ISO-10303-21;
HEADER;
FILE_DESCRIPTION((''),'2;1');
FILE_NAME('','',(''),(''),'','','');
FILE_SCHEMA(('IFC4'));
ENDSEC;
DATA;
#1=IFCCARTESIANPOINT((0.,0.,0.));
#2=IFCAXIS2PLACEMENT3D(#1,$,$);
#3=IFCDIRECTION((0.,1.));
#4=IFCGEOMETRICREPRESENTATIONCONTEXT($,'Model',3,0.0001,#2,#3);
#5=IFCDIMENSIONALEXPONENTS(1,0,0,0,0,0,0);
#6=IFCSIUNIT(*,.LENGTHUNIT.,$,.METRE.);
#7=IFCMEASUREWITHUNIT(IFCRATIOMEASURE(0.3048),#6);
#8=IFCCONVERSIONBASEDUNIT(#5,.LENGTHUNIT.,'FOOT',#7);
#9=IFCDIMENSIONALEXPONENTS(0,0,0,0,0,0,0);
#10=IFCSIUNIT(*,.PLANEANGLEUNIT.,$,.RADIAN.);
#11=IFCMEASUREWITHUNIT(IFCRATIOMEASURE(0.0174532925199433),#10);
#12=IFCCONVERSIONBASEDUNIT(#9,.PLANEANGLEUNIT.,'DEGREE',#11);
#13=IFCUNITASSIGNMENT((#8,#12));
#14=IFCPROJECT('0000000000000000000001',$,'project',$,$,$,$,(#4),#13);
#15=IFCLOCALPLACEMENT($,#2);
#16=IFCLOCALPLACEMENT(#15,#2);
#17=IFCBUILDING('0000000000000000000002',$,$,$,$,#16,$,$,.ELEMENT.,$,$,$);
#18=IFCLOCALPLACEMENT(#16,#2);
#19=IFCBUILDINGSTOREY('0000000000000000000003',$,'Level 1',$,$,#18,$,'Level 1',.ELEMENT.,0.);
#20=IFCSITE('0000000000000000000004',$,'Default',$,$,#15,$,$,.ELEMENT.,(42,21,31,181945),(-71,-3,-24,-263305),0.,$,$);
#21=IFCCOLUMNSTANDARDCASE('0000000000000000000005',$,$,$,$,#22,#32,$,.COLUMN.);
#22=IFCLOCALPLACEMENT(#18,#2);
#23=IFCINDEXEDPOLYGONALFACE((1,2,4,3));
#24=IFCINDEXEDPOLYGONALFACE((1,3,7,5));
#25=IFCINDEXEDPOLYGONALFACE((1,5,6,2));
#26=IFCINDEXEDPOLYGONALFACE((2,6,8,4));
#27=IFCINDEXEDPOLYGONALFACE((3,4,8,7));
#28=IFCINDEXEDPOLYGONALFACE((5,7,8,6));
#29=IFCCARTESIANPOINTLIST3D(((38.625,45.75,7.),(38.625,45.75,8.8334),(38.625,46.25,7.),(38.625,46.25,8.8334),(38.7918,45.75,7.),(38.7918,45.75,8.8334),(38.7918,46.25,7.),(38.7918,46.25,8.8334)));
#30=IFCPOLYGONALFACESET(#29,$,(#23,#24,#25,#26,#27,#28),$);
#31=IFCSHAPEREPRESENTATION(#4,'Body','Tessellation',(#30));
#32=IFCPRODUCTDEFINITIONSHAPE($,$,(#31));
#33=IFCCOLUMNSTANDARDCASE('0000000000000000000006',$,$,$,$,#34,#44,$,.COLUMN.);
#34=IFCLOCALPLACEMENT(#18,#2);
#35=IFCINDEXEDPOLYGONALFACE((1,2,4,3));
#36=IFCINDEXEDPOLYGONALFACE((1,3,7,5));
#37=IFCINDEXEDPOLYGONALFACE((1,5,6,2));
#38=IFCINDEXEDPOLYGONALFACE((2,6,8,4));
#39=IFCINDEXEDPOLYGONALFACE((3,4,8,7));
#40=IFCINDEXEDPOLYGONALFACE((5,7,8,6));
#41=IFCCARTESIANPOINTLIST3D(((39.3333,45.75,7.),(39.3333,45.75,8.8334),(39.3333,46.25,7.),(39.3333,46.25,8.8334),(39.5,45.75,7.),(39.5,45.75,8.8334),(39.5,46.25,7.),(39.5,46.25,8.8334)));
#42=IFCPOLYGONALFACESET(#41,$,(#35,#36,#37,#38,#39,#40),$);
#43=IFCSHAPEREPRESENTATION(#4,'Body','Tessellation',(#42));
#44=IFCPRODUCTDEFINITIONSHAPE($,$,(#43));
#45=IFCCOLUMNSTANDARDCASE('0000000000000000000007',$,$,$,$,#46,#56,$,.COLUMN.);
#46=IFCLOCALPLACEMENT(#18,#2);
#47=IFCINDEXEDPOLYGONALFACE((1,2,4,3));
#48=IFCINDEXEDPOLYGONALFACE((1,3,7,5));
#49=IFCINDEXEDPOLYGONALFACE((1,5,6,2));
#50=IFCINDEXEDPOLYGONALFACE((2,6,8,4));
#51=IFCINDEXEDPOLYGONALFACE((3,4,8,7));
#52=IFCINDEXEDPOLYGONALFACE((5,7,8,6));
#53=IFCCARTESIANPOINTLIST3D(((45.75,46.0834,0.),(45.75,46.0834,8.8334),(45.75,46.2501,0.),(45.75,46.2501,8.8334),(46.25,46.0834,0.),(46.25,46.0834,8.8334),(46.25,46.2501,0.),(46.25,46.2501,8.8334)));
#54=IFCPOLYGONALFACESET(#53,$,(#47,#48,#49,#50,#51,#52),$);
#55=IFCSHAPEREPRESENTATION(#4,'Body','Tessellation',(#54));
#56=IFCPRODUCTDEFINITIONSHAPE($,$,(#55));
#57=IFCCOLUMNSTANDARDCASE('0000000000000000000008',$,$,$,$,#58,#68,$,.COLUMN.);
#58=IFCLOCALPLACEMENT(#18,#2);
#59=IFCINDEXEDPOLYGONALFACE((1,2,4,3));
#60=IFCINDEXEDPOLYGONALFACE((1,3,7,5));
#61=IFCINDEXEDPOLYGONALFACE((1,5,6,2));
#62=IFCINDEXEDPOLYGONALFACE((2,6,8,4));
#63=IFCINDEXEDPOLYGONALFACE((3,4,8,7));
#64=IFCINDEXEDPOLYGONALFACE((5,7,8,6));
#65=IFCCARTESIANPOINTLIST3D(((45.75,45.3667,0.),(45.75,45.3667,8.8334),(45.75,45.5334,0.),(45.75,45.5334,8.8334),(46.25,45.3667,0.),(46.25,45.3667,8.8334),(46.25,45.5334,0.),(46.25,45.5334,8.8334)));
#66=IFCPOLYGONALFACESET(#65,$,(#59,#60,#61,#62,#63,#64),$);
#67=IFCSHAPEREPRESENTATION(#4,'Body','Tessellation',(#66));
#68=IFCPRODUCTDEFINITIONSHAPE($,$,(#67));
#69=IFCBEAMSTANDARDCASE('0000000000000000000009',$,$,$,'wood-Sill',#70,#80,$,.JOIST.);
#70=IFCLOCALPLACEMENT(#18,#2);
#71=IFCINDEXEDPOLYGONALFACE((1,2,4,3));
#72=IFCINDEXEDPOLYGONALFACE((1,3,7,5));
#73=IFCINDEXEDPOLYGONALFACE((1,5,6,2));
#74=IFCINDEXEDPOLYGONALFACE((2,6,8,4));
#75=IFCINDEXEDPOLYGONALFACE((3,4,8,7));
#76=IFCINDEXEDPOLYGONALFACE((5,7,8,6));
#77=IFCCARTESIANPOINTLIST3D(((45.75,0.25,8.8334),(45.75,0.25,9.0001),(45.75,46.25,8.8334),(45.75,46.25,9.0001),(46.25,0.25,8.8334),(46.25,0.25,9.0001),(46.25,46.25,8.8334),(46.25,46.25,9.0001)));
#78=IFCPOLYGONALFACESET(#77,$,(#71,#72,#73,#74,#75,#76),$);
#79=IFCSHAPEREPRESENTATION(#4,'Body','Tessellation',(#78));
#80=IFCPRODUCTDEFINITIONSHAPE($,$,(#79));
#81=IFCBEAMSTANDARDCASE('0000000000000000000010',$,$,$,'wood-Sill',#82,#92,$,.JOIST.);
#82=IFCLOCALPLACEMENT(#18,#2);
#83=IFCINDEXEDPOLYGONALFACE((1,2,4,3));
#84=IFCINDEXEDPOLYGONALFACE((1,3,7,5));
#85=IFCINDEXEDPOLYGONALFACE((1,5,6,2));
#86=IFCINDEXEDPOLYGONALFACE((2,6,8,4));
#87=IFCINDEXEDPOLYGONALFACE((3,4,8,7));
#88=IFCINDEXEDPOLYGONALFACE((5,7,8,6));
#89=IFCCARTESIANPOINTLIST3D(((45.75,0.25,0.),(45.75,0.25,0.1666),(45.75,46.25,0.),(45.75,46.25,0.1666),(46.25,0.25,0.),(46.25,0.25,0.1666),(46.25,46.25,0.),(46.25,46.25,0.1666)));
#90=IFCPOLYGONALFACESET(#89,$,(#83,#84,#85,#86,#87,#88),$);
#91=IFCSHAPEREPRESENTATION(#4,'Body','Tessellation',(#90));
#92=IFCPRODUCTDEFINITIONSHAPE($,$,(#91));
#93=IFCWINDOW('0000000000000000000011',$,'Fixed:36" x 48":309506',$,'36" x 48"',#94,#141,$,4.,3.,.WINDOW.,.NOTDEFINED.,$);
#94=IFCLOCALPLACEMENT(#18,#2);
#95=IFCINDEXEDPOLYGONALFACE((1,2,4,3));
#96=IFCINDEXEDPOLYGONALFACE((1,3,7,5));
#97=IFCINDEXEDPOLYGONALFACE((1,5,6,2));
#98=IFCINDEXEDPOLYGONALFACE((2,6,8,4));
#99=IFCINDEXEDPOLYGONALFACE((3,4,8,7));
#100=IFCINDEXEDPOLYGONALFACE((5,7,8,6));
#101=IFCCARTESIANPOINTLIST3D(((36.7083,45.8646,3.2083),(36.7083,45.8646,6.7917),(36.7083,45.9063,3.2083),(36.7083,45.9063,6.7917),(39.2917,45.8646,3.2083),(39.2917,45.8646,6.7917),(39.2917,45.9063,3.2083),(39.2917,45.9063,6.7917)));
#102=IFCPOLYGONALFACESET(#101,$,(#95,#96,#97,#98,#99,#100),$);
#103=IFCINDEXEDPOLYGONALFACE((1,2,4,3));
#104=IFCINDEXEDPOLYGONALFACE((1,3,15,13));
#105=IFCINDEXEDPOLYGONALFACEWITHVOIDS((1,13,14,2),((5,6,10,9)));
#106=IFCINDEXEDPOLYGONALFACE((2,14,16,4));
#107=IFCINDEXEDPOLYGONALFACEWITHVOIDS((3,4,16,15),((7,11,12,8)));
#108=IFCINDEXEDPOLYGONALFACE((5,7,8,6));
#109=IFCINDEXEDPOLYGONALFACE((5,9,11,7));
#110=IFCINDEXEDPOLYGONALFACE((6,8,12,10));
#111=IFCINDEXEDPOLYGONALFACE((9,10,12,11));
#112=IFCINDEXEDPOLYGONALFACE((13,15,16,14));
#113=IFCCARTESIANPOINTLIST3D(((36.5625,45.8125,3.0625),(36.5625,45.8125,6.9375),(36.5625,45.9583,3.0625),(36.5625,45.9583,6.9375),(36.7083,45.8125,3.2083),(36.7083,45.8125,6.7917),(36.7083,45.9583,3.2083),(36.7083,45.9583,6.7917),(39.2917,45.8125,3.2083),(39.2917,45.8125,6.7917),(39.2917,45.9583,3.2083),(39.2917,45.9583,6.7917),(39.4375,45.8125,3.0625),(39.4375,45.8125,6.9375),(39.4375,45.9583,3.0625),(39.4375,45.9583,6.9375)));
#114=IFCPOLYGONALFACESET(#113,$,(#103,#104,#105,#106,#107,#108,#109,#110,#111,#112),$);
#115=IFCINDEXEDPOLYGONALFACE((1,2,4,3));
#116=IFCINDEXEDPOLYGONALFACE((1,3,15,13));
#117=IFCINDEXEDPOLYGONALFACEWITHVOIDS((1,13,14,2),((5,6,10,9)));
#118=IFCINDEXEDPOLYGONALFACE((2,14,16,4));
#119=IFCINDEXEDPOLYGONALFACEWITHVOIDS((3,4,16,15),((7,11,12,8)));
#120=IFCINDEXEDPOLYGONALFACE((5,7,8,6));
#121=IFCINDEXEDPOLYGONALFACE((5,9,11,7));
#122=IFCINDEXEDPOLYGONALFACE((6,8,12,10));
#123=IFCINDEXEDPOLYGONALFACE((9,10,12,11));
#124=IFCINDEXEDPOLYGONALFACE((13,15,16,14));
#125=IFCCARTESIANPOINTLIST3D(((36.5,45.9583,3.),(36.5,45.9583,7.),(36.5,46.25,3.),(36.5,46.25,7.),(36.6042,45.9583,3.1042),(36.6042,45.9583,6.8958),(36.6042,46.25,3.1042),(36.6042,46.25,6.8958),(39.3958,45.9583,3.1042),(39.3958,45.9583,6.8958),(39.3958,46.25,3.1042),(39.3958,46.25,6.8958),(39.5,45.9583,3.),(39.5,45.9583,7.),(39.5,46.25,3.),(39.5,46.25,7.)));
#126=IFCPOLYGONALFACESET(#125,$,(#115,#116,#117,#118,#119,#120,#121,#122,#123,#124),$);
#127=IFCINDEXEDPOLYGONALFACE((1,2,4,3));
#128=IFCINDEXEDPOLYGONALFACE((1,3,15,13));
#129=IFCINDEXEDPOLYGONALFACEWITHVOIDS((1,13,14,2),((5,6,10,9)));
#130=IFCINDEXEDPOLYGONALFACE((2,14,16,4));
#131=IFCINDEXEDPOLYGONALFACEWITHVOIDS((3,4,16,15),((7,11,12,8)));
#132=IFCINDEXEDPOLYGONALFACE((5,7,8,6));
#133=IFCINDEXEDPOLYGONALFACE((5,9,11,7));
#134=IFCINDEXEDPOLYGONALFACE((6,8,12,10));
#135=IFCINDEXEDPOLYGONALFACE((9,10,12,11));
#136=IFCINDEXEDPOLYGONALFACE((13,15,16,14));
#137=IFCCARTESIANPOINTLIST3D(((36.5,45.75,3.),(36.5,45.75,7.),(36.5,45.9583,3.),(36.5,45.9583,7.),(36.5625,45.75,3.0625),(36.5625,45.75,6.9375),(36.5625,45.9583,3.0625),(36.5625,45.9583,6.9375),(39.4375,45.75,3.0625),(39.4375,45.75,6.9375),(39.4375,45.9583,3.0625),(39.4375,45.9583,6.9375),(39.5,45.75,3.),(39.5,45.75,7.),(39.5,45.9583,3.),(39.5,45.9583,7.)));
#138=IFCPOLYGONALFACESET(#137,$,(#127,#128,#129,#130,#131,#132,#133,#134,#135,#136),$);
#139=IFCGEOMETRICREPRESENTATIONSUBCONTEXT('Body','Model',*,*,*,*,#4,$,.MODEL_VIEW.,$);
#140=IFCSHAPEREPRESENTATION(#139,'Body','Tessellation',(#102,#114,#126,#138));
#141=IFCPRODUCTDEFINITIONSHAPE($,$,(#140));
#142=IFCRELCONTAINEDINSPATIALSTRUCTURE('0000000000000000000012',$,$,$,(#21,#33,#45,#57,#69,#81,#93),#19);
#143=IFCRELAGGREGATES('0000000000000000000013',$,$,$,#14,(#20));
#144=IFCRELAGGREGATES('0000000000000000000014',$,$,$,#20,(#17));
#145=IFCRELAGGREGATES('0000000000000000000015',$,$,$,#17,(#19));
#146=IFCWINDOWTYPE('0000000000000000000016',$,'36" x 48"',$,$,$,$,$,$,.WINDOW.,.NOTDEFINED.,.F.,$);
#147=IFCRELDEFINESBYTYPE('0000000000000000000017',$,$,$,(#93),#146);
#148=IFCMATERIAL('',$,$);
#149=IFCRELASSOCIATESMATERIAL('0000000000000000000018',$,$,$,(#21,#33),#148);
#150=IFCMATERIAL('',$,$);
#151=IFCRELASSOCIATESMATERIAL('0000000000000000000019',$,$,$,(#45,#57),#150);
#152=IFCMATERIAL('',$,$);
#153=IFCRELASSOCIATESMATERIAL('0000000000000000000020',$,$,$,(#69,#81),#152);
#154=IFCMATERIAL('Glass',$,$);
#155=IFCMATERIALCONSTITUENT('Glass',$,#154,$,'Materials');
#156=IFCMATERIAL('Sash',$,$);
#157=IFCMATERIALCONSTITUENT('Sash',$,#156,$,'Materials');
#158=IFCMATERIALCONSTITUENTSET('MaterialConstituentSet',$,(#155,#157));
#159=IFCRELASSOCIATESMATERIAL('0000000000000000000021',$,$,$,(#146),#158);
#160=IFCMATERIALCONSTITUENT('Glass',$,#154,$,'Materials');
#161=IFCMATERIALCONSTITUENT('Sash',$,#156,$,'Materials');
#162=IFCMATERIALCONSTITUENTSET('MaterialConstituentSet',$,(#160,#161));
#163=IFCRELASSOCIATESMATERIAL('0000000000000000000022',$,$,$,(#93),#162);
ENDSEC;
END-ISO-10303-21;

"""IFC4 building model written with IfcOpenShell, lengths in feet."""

from ifc_helpers import new_model, entity, si_unit, converted_unit, direction, frame, frame_2d, origin, origin_with_axes, place, context, subcontext, project, spatial, polyline, rectangle, outline, extrude, source, transform, mapped, material, constituent, constituent_set, type_object, type_shapes, element, save


model = new_model("IFC4")

# Units and contexts
model_context = context("Model", 3, precision=0.0001, world=origin(), true_north=direction((0.0, 1.0)))
body_context = subcontext(model_context, "Body", "Model", "MODEL_VIEW")
ifc_project = project(units=[converted_unit("LENGTHUNIT", "FOOT", entity("IfcRatioMeasure", 0.3048), si_unit("LENGTHUNIT", "METRE"), dimensions=[1, 0, 0, 0, 0, 0, 0]), converted_unit("PLANEANGLEUNIT", "DEGREE", entity("IfcRatioMeasure", 0.0174532925199433), si_unit("PLANEANGLEUNIT", "RADIAN"), dimensions=[0, 0, 0, 0, 0, 0, 0])], contexts=[model_context])

# Site, building, storey
site_placement = place(None, origin())
site = spatial("IfcSite", under=ifc_project, at=site_placement, Name="Default", CompositionType="ELEMENT", RefLatitude=(42, 21, 31, 181945), RefLongitude=(-71, -3, -24, -263305), RefElevation=0.0)
building_placement = place(site_placement, origin())
building = spatial("IfcBuilding", under=site, at=building_placement, CompositionType="ELEMENT")
storey_placement = place(building_placement, origin())
storey = spatial("IfcBuildingStorey", under=building, at=storey_placement, Name="Level 1", LongName="Level 1", CompositionType="ELEMENT", Elevation=0.0)

# Columns
placement_1 = place(storey_placement, frame((-0.25, 46.0, 0.0)))
ifc_material_1 = material(Name="")
for number, where, z_axis, x_axis in (
    (1, (38.9584, 0.0, 7.0), (0.0, 0.0, 1.0), (1.0, 0.0, 0.0)),
    (2, (39.6667, 0.0, 7.0), (0.0, 0.0, 1.0), (1.0, 0.0, 0.0)),
):
    element("IfcColumnStandardCase", number, at=place(placement_1, frame(where, z_axis=z_axis, x_axis=x_axis)), inside=storey, material=ifc_material_1, PredefinedType="COLUMN", context=model_context, shape_type="SweptSolid", body=[
        extrude(rectangle(XDim=0.1667, YDim=0.5), origin(), (0.0, 0.0, 1.0), 1.8334),
    ])
ifc_material_2 = material(Name="")
placement_2 = place(storey_placement, frame((46.0, 46.25, 0.0), z_axis=(0.0, 0.0, 1.0), x_axis=(0.0, -1.0, 0.0)))
for number, where, z_axis, x_axis in (
    (3, (0.0833, 0.0, 0.0), (0.0, 0.0, 1.0), (1.0, 0.0, 0.0)),
    (4, (0.8, 0.0, 0.0), (0.0, 0.0, 1.0), (1.0, 0.0, 0.0)),
):
    element("IfcColumnStandardCase", number, at=place(placement_2, frame(where, z_axis=z_axis, x_axis=x_axis)), inside=storey, material=ifc_material_2, PredefinedType="COLUMN", context=model_context, shape_type="SweptSolid", body=[
        extrude(rectangle(XDim=0.1667, YDim=0.5), origin(), (0.0, 0.0, 1.0), 8.8334),
    ])

# Beams
ifc_material_3 = material(Name="")
for number, where, z_axis, x_axis in (
    (5, (0.0, 0.0, 8.9167), (1.0, 0.0, 0.0), (0.0, 0.0, 1.0)),
    (6, (0.0, 0.0, 0.0833), (1.0, 0.0, 0.0), (0.0, 0.0, 1.0)),
):
    element("IfcBeamStandardCase", number, at=place(placement_2, frame(where, z_axis=z_axis, x_axis=x_axis)), inside=storey, material=ifc_material_3, ObjectType="wood-Sill", PredefinedType="JOIST", context=model_context, shape_type="SweptSolid", body=[
        extrude(rectangle(XDim=0.1667, YDim=0.5), origin_with_axes(), (0.0, 0.0, 1.0), 46.0),
    ])

# Window
ifc_material_4 = material(Name="Glass")
ifc_constituent_1 = constituent(ifc_material_4, Name="Glass", Category="Materials")
ifc_material_5 = material(Name="Sash")
ifc_constituent_2 = constituent(ifc_material_5, Name="Sash", Category="Materials")
ifc_constituent_set_1 = constituent_set(constituents=[ifc_constituent_1, ifc_constituent_2], Name="MaterialConstituentSet")
ifc_constituent_3 = constituent(ifc_material_4, Name="Glass", Category="Materials")
ifc_constituent_4 = constituent(ifc_material_5, Name="Sash", Category="Materials")
ifc_constituent_set_2 = constituent_set(constituents=[ifc_constituent_3, ifc_constituent_4], Name="MaterialConstituentSet")
window_type = type_object("IfcWindowType", Name="36\" x 48\"", ParameterTakesPrecedence=False, PartitioningType="NOTDEFINED", PredefinedType="WINDOW", material=ifc_constituent_set_2)
shared_shape = source(origin(), body_context, "Body", "SweptSolid", [
    extrude(rectangle(XDim=0.0417, YDim=2.5833, at=frame_2d((0.0, 0.0), x_axis=(1.0, 0.0))), frame((1.5, 0.3646, 0.2083), z_axis=(0.0, 0.0, 1.0), x_axis=(0.0, 1.0, 0.0)), (0.0, 0.0, 1.0), 3.5833),
    extrude(outline(polyline([(-1.4375, -1.9375), (1.4375, -1.9375), (1.4375, 1.9375), (-1.4375, 1.9375), (-1.4375, -1.9375)]), holes=[polyline([(-1.2917, -1.7917), (-1.2917, 1.7917), (1.2917, 1.7917), (1.2917, -1.7917), (-1.2917, -1.7917)])]), frame((1.5, 0.2917, 2.0), z_axis=(0.0, 1.0, 0.0), x_axis=(1.0, 0.0, 0.0)), (0.0, 0.0, 1.0), 0.1458),
    extrude(outline(polyline([(-1.5, -2.0), (1.5, -2.0), (1.5, 2.0), (-1.5, 2.0), (-1.5, -2.0)]), holes=[polyline([(-1.3958, -1.8958), (-1.3958, 1.8958), (1.3958, 1.8958), (1.3958, -1.8958), (-1.3958, -1.8958)])]), frame((1.5, 0.0, 2.0), z_axis=(0.0, 1.0, 0.0), x_axis=(1.0, 0.0, 0.0)), (0.0, 0.0, 1.0), 0.2917),
    extrude(outline(polyline([(-2.0, -1.5), (2.0, -1.5), (2.0, 1.5), (-2.0, 1.5), (-2.0, -1.5)]), holes=[polyline([(-1.9375, -1.4375), (-1.9375, 1.4375), (1.9375, 1.4375), (1.9375, -1.4375), (-1.9375, -1.4375)])]), frame((1.5, 0.2917, 2.0), z_axis=(0.0, 1.0, 0.0), x_axis=(0.0, 0.0, -1.0)), (0.0, 0.0, 1.0), 0.2083),
])
type_shapes(window_type, [shared_shape])
placement_3 = place(placement_1, frame((39.75, 0.25, 3.0)))
window_placement = place(placement_3, frame((0.0, 0.0, 0.0), z_axis=(0.0, 0.0, 1.0), x_axis=(-1.0, 0.0, 0.0)))
element("IfcWindow", 7, at=window_placement, inside=storey, type_object=window_type, material=ifc_constituent_set_1, Name="Fixed:36\" x 48\":309506", ObjectType="36\" x 48\"", OverallHeight=4.0, OverallWidth=3.0, PartitioningType="NOTDEFINED", PredefinedType="WINDOW", context=body_context, shape_type="MappedRepresentation", body=[
    mapped(shared_shape, transform((0.0, 0.0, 0.0), scale=1.0)),
])

save(model, "model.ifc")
